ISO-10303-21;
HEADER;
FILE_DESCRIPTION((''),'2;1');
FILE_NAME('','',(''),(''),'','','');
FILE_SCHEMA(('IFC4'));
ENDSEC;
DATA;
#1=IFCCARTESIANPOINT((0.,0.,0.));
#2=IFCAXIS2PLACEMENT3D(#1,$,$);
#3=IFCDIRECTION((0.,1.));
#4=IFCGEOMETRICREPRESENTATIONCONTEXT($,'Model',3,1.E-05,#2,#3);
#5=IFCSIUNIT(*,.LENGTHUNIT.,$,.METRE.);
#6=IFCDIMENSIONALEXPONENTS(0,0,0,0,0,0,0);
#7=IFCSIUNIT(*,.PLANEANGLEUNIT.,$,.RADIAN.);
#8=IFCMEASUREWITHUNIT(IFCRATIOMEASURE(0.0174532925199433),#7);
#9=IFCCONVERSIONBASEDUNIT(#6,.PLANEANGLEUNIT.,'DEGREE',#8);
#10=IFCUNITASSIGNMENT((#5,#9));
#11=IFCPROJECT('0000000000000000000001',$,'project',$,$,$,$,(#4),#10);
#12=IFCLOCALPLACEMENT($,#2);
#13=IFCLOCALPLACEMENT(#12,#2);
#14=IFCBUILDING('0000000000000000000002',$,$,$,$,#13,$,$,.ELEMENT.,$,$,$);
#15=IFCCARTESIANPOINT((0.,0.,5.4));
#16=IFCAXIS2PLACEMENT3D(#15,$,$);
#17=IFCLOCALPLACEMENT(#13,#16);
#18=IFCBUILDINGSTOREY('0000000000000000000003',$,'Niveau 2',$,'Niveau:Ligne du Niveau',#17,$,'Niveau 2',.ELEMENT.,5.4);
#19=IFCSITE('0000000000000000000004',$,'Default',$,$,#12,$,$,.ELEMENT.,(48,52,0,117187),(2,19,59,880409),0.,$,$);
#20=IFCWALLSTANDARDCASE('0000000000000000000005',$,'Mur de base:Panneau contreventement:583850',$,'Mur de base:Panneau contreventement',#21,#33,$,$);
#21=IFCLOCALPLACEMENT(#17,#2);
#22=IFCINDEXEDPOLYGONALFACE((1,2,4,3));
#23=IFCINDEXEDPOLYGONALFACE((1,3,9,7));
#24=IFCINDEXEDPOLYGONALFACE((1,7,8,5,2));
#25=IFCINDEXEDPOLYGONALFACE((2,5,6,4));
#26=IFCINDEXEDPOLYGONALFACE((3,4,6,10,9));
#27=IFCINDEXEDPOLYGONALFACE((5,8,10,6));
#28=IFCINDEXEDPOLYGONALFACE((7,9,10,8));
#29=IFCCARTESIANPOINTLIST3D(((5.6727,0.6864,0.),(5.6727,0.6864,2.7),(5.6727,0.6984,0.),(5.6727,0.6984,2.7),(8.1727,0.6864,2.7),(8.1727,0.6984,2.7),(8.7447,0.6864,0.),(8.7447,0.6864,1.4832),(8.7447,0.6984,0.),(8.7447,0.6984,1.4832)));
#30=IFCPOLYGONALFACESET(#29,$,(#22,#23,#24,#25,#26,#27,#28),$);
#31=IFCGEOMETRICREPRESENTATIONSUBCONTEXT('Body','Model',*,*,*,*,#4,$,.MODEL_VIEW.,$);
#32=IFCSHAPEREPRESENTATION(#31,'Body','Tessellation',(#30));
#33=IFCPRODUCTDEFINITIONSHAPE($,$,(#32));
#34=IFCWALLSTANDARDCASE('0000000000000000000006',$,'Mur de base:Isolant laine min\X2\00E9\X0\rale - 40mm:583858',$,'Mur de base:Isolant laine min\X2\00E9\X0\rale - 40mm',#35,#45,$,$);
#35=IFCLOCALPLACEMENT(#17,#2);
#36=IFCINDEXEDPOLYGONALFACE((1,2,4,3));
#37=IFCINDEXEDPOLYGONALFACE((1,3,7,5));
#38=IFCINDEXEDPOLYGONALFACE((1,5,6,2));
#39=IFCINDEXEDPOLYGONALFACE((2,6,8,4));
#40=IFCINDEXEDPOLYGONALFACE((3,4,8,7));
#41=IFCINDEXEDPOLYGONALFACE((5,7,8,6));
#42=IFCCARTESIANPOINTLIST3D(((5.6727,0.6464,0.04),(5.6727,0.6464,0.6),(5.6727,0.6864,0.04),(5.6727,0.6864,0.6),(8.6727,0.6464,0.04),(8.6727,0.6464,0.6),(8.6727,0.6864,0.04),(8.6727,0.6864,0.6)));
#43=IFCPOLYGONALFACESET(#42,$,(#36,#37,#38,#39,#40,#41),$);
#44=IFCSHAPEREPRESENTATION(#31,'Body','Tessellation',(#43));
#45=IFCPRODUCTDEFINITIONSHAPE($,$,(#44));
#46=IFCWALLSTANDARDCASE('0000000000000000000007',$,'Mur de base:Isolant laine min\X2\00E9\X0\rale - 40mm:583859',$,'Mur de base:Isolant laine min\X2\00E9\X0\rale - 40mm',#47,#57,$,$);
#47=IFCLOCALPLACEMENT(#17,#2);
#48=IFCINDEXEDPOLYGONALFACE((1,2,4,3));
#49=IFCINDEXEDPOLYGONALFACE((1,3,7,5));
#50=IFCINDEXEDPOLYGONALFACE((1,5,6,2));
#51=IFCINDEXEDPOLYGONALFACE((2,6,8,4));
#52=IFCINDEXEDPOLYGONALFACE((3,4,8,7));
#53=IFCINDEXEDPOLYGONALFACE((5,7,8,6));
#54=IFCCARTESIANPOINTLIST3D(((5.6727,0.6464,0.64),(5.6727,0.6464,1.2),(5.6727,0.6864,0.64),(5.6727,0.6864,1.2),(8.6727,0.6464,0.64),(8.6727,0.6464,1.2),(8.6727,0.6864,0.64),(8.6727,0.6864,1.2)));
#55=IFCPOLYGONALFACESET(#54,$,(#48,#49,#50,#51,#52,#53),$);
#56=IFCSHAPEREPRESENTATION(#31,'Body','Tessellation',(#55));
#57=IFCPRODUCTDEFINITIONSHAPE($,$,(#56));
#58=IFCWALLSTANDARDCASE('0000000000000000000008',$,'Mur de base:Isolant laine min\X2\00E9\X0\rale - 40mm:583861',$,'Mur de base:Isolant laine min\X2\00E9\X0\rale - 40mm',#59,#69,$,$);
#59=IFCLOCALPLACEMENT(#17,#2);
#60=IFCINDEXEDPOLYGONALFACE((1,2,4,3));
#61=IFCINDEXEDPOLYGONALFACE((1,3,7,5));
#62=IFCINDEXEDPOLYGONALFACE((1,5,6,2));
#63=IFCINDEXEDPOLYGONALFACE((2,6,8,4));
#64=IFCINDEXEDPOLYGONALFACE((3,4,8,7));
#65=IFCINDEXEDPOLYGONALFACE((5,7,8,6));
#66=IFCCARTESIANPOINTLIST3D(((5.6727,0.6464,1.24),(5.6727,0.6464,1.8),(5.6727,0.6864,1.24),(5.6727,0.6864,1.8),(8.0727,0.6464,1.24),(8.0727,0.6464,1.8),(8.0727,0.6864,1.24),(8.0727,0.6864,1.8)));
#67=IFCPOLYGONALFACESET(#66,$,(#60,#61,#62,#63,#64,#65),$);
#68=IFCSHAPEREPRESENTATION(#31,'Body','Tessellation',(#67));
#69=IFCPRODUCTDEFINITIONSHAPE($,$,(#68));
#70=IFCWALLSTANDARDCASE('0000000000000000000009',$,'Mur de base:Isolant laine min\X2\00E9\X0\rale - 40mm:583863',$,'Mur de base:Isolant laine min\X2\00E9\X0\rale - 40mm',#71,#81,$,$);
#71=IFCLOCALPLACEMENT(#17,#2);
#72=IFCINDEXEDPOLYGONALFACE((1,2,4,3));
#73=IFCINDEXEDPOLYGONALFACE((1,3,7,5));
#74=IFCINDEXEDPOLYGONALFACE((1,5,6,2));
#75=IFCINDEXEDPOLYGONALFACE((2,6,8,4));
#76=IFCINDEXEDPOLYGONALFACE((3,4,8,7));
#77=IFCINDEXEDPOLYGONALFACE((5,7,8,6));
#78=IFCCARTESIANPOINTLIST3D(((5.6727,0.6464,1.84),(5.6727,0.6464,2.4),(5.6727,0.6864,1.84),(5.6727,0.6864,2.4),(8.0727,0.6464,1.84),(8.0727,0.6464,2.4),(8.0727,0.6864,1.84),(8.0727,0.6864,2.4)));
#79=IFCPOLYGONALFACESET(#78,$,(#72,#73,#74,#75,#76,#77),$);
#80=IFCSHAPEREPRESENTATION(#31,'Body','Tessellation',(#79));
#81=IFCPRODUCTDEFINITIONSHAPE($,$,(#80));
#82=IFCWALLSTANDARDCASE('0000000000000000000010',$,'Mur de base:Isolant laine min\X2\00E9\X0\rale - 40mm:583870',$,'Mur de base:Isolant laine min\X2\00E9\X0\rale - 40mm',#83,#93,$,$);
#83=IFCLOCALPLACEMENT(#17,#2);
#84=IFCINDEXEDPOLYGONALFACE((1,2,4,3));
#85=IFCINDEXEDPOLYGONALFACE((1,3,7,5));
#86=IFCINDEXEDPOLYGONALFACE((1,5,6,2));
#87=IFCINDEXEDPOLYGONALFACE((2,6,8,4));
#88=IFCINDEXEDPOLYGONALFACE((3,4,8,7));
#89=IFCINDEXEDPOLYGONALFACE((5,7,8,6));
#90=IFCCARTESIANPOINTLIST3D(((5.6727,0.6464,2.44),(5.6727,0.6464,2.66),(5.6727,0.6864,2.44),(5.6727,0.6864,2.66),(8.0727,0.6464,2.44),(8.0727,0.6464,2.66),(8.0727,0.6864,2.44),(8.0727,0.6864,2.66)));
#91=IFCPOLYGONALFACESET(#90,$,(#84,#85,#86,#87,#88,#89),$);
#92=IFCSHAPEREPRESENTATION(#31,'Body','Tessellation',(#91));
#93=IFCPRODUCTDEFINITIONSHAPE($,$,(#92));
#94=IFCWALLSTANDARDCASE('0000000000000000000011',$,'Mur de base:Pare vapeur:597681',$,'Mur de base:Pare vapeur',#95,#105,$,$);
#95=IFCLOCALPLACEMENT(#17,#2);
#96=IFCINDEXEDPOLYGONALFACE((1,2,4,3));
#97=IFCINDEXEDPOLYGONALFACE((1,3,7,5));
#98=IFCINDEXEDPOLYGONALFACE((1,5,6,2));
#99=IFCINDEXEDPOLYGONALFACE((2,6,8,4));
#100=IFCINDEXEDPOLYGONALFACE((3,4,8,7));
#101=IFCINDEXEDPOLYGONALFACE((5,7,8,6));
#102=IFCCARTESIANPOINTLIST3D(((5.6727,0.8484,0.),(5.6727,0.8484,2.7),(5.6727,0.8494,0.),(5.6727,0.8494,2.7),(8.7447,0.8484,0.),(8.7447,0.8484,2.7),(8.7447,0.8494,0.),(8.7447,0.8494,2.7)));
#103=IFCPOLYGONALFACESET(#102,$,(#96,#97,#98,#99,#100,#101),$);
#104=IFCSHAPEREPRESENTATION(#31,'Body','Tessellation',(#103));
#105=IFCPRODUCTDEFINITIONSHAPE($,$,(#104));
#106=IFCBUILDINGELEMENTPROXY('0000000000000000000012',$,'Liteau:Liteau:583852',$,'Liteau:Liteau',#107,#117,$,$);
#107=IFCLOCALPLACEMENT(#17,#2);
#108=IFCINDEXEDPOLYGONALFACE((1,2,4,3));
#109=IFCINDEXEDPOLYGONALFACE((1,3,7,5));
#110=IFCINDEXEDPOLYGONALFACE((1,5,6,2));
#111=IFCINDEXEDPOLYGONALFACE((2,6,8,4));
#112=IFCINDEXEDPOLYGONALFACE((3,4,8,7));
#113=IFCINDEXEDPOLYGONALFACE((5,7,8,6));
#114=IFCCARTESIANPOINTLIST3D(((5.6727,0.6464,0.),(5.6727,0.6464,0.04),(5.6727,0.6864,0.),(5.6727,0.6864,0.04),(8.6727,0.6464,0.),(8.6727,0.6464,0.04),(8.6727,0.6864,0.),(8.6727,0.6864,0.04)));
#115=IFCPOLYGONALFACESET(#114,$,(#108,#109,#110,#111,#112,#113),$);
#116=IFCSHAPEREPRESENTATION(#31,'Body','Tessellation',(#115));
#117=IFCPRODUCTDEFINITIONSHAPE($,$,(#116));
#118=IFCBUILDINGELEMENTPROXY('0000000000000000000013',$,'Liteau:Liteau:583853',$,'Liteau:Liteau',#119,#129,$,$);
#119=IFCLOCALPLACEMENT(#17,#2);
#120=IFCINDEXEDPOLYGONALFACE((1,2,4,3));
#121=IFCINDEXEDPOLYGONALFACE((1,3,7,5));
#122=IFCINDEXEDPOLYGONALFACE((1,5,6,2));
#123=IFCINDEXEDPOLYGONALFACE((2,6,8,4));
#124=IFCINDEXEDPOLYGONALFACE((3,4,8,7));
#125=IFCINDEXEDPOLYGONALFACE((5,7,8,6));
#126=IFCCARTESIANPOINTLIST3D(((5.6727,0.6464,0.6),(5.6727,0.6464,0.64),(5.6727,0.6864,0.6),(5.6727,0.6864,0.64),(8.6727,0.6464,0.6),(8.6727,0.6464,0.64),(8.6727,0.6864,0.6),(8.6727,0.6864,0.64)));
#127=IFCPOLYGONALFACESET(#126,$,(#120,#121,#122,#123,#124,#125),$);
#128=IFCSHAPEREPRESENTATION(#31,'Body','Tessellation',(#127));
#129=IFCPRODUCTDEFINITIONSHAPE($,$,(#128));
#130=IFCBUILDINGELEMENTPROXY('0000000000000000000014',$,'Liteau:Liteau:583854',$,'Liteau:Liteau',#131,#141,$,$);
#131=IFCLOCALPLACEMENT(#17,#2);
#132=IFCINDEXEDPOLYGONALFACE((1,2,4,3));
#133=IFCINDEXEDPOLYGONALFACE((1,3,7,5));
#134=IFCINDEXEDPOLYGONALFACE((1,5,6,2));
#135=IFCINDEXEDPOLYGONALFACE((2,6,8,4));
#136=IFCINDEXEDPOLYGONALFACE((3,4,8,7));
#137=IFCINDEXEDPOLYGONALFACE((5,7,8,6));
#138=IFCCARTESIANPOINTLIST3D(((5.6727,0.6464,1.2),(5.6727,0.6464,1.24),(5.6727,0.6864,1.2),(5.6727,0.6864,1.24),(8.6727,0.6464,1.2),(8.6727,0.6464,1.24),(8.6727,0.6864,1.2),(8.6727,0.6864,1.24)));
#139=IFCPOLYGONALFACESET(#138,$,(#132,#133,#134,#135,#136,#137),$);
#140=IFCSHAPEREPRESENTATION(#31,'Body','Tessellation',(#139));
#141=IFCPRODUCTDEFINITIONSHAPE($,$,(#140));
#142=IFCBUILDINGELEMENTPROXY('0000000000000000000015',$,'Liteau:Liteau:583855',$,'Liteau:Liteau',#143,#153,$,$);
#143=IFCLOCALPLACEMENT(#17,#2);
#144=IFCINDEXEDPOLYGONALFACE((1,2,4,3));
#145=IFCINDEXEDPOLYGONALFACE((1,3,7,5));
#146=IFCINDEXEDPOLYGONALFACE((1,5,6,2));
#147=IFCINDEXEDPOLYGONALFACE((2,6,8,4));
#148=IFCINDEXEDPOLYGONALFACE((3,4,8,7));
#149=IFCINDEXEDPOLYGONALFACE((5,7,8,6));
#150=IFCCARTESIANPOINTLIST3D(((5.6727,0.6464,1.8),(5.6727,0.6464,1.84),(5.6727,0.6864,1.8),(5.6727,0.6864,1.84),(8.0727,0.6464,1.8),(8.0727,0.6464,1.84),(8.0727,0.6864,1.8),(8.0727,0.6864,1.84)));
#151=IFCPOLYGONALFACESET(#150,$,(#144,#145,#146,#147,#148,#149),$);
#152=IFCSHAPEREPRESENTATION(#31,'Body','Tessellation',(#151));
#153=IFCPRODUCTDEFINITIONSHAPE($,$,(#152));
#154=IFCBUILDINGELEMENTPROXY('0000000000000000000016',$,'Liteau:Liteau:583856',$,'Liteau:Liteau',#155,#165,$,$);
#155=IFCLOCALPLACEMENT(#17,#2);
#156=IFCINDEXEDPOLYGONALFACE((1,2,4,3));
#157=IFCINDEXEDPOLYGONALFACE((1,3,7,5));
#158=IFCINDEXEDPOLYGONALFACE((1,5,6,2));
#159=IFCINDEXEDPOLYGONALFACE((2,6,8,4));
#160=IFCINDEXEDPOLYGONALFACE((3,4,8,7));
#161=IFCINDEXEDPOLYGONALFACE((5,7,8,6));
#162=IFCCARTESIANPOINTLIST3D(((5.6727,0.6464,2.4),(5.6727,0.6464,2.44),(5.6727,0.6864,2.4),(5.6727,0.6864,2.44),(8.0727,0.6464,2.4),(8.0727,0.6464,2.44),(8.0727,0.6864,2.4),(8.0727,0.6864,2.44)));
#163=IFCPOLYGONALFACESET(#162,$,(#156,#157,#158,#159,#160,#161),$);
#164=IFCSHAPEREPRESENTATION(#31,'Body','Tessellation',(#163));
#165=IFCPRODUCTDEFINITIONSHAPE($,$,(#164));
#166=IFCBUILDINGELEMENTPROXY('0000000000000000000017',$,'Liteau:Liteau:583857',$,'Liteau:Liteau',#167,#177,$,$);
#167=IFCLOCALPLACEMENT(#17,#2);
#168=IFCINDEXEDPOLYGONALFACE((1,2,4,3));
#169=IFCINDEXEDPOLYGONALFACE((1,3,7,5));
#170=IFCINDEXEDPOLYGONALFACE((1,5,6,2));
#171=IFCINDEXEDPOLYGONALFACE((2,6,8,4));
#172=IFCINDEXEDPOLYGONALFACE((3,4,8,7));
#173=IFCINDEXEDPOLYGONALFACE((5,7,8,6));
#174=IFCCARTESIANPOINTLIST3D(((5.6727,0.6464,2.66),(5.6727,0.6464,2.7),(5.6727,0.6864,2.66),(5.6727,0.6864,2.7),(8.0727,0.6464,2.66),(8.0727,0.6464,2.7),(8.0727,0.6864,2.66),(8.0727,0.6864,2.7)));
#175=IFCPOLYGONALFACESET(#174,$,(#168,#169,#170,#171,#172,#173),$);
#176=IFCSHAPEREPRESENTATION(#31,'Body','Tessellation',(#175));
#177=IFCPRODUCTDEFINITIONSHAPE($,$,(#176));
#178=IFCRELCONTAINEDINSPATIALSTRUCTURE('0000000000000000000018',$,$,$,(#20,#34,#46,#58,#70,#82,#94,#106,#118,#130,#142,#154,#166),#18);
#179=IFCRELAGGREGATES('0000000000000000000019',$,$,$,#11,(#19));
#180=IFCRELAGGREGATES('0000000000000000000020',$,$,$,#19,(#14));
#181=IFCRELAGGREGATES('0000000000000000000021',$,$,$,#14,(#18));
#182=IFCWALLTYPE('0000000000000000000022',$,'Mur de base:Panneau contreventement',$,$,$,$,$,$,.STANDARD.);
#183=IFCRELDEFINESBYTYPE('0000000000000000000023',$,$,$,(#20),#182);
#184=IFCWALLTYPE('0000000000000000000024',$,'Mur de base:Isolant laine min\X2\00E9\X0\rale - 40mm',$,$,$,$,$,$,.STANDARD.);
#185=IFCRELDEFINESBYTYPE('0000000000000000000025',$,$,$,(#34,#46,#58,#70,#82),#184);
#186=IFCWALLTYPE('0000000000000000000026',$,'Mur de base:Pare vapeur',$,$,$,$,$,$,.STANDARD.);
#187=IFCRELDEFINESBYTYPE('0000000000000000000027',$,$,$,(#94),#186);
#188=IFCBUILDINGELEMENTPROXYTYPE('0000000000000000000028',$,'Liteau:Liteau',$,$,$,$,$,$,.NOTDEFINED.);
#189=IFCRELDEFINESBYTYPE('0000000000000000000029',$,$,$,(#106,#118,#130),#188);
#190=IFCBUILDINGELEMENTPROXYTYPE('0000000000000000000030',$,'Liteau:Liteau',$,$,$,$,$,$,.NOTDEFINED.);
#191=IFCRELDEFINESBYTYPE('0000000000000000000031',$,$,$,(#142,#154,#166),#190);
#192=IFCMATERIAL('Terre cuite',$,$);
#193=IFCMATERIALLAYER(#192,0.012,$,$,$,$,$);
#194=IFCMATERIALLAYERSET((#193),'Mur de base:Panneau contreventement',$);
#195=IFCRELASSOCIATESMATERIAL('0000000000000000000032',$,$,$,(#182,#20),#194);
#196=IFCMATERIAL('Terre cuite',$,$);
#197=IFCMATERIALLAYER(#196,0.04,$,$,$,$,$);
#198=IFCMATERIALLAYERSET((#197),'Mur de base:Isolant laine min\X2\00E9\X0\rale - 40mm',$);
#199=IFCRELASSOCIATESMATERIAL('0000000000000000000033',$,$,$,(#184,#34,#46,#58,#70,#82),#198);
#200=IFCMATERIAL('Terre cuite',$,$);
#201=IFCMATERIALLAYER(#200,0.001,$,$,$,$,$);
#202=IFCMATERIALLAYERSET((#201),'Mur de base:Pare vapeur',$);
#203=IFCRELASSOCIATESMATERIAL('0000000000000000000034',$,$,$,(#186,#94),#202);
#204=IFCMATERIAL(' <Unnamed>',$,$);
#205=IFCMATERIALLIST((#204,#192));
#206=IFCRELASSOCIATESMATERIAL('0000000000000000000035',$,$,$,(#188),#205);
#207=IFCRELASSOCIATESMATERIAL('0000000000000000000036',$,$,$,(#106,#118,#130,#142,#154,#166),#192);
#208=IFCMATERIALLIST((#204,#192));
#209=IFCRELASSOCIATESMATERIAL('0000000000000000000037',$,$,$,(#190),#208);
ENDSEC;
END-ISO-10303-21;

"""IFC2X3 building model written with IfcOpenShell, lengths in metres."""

from ifc_helpers import new_model, entity, si_unit, converted_unit, direction, frame, frame_2d, origin, origin_2d_with_axis, place, context, subcontext, project, spatial, rectangle, extrude, clip, halfspace, source, transform, mapped, material, material_list, layer, layer_set, layer_usage, type_object, type_shapes, element, save


model = new_model("IFC2X3")

# Units and contexts
model_context = context("Model", 3, precision=1e-05, world=origin(), true_north=direction((0.0, 1.0)))
body_context = subcontext(model_context, "Body", "Model", "MODEL_VIEW")
ifc_project = project(units=[si_unit("LENGTHUNIT", "METRE"), converted_unit("PLANEANGLEUNIT", "DEGREE", entity("IfcRatioMeasure", 0.0174532925199433), si_unit("PLANEANGLEUNIT", "RADIAN"), dimensions=[0, 0, 0, 0, 0, 0, 0])], contexts=[model_context])

# Site, building, storey
site_placement = place(None, origin())
site = spatial("IfcSite", under=ifc_project, at=site_placement, Name="Default", CompositionType="ELEMENT", RefLatitude=(48, 52, 0, 117187), RefLongitude=(2, 19, 59, 880409), RefElevation=0.0)
building_placement = place(site_placement, origin())
building = spatial("IfcBuilding", under=site, at=building_placement, CompositionType="ELEMENT")
storey_placement = place(building_placement, frame((0.0, 0.0, 5.4)))
storey = spatial("IfcBuildingStorey", under=building, at=storey_placement, Name="Niveau 2", ObjectType="Niveau:Ligne du Niveau", LongName="Niveau 2", CompositionType="ELEMENT", Elevation=5.4)

# Shared definitions
ifc_material_1 = material(Name="Terre cuite")

# Walls
ifc_layer_1 = layer(ifc_material_1, 0.012)
ifc_layer_set_1 = layer_set([ifc_layer_1], Name="Mur de base:Panneau contreventement")
ifc_layer_usage_1 = layer_usage(ifc_layer_set_1, "AXIS2", "NEGATIVE", 0.006)
wall_type_1 = type_object("IfcWallType", Name="Mur de base:Panneau contreventement", PredefinedType="STANDARD", material=ifc_layer_set_1)
wall_1_placement = place(storey_placement, frame((5.6727, 0.6924, 0.0)))
element("IfcWallStandardCase", 1, at=wall_1_placement, inside=storey, type_object=wall_type_1, material=ifc_layer_usage_1, Name="Mur de base:Panneau contreventement:583850", ObjectType="Mur de base:Panneau contreventement", context=body_context, shape_type="Clipping", body=[
    clip(extrude(rectangle(XDim=3.072, YDim=0.012, at=frame_2d((1.536, 0.0), x_axis=(-1.0, 0.0))), origin(), (0.0, 0.0, 1.0), 2.7), halfspace(frame((2.5, -0.006, 2.7), z_axis=(0.904996, 0.0, 0.425419), x_axis=(0.0, 1.0, 0.0)), False)),
])
ifc_material_2 = material(Name="Terre cuite")
ifc_layer_2 = layer(ifc_material_2, 0.04)
ifc_layer_set_2 = layer_set([ifc_layer_2], Name="Mur de base:Isolant laine minérale - 40mm")
ifc_layer_usage_2 = layer_usage(ifc_layer_set_2, "AXIS2", "NEGATIVE", 0.02)
wall_type_2 = type_object("IfcWallType", Name="Mur de base:Isolant laine minérale - 40mm", PredefinedType="STANDARD", material=ifc_layer_set_2)
wall_2_placement = place(storey_placement, frame((5.6727, 0.6664, 0.04)))
element("IfcWallStandardCase", 2, at=wall_2_placement, inside=storey, type_object=wall_type_2, material=ifc_layer_usage_2, Name="Mur de base:Isolant laine minérale - 40mm:583858", ObjectType="Mur de base:Isolant laine minérale - 40mm", context=body_context, shape_type="SweptSolid", body=[
    extrude(rectangle(XDim=3.0, YDim=0.04, at=frame_2d((1.5, 0.0), x_axis=(-1.0, 0.0))), origin(), (0.0, 0.0, 1.0), 0.56),
])
ifc_layer_usage_3 = layer_usage(ifc_layer_set_2, "AXIS2", "NEGATIVE", 0.02)
wall_3_placement = place(storey_placement, frame((5.6727, 0.6664, 0.64)))
element("IfcWallStandardCase", 3, at=wall_3_placement, inside=storey, type_object=wall_type_2, material=ifc_layer_usage_3, Name="Mur de base:Isolant laine minérale - 40mm:583859", ObjectType="Mur de base:Isolant laine minérale - 40mm", context=body_context, shape_type="SweptSolid", body=[
    extrude(rectangle(XDim=3.0, YDim=0.04, at=frame_2d((1.5, 0.0), x_axis=(-1.0, 0.0))), origin(), (0.0, 0.0, 1.0), 0.56),
])
ifc_layer_usage_4 = layer_usage(ifc_layer_set_2, "AXIS2", "NEGATIVE", 0.02)
wall_4_placement = place(storey_placement, frame((5.6727, 0.6664, 1.24)))
element("IfcWallStandardCase", 4, at=wall_4_placement, inside=storey, type_object=wall_type_2, material=ifc_layer_usage_4, Name="Mur de base:Isolant laine minérale - 40mm:583861", ObjectType="Mur de base:Isolant laine minérale - 40mm", context=body_context, shape_type="SweptSolid", body=[
    extrude(rectangle(XDim=2.4, YDim=0.04, at=frame_2d((1.2, 0.0), x_axis=(-1.0, 0.0))), origin(), (0.0, 0.0, 1.0), 0.56),
])
ifc_layer_usage_5 = layer_usage(ifc_layer_set_2, "AXIS2", "NEGATIVE", 0.02)
wall_5_placement = place(storey_placement, frame((5.6727, 0.6664, 1.84)))
element("IfcWallStandardCase", 5, at=wall_5_placement, inside=storey, type_object=wall_type_2, material=ifc_layer_usage_5, Name="Mur de base:Isolant laine minérale - 40mm:583863", ObjectType="Mur de base:Isolant laine minérale - 40mm", context=body_context, shape_type="SweptSolid", body=[
    extrude(rectangle(XDim=2.4, YDim=0.04, at=frame_2d((1.2, 0.0), x_axis=(-1.0, 0.0))), origin(), (0.0, 0.0, 1.0), 0.56),
])
ifc_layer_usage_6 = layer_usage(ifc_layer_set_2, "AXIS2", "NEGATIVE", 0.02)
wall_6_placement = place(storey_placement, frame((5.6727, 0.6664, 2.44)))
element("IfcWallStandardCase", 6, at=wall_6_placement, inside=storey, type_object=wall_type_2, material=ifc_layer_usage_6, Name="Mur de base:Isolant laine minérale - 40mm:583870", ObjectType="Mur de base:Isolant laine minérale - 40mm", context=body_context, shape_type="SweptSolid", body=[
    extrude(rectangle(XDim=2.4, YDim=0.04, at=frame_2d((1.2, 0.0), x_axis=(-1.0, 0.0))), origin(), (0.0, 0.0, 1.0), 0.22),
])
ifc_material_3 = material(Name="Terre cuite")
ifc_layer_3 = layer(ifc_material_3, 0.001)
ifc_layer_set_3 = layer_set([ifc_layer_3], Name="Mur de base:Pare vapeur")
ifc_layer_usage_7 = layer_usage(ifc_layer_set_3, "AXIS2", "NEGATIVE", 0.0005)
wall_type_3 = type_object("IfcWallType", Name="Mur de base:Pare vapeur", PredefinedType="STANDARD", material=ifc_layer_set_3)
wall_7_placement = place(storey_placement, frame((5.6727, 0.8489, 0.0)))
element("IfcWallStandardCase", 7, at=wall_7_placement, inside=storey, type_object=wall_type_3, material=ifc_layer_usage_7, Name="Mur de base:Pare vapeur:597681", ObjectType="Mur de base:Pare vapeur", context=body_context, shape_type="SweptSolid", body=[
    extrude(rectangle(XDim=3.072, YDim=0.001, at=frame_2d((1.536, 0.0), x_axis=(-1.0, 0.0))), origin(), (0.0, 0.0, 1.0), 2.7),
])

# Building element proxies
ifc_material_4 = material(Name=" <Unnamed>")
ifc_material_list_1 = material_list([ifc_material_4, ifc_material_1])
building_element_proxy_type_1 = type_object("IfcBuildingElementProxyType", Name="Liteau:Liteau", PredefinedType="NOTDEFINED", material=ifc_material_list_1)
shared_shape_1 = source(origin(), body_context, "Body", "SweptSolid", [
    extrude(rectangle(XDim=3.0, YDim=0.04, at=origin_2d_with_axis()), frame((1.5, -0.02, 0.0), z_axis=(0.0, 0.0, 1.0), x_axis=(-1.0, 0.0, 0.0)), (0.0, 0.0, 1.0), 0.04),
])
type_shapes(building_element_proxy_type_1, [shared_shape_1])
for number, where, name in (
    (8, (5.6727, 0.6864, 0.0), "Liteau:Liteau:583852"),
    (9, (5.6727, 0.6864, 0.6), "Liteau:Liteau:583853"),
    (10, (5.6727, 0.6864, 1.2), "Liteau:Liteau:583854"),
):
    element("IfcBuildingElementProxy", number, at=place(storey_placement, frame(where)), inside=storey, type_object=building_element_proxy_type_1, material=ifc_material_1, Name=name, ObjectType="Liteau:Liteau", context=body_context, shape_type="MappedRepresentation", body=[
        mapped(shared_shape_1, transform((0.0, 0.0, 0.0), scale=1.0)),
    ])
ifc_material_list_2 = material_list([ifc_material_4, ifc_material_1])
building_element_proxy_type_2 = type_object("IfcBuildingElementProxyType", Name="Liteau:Liteau", PredefinedType="NOTDEFINED", material=ifc_material_list_2)
shared_shape_2 = source(origin(), body_context, "Body", "SweptSolid", [
    extrude(rectangle(XDim=2.4, YDim=0.04, at=origin_2d_with_axis()), frame((1.2, -0.02, 0.0), z_axis=(0.0, 0.0, 1.0), x_axis=(-1.0, 0.0, 0.0)), (0.0, 0.0, 1.0), 0.04),
])
type_shapes(building_element_proxy_type_2, [shared_shape_2])
for number, where, name in (
    (11, (5.6727, 0.6864, 1.8), "Liteau:Liteau:583855"),
    (12, (5.6727, 0.6864, 2.4), "Liteau:Liteau:583856"),
    (13, (5.6727, 0.6864, 2.66), "Liteau:Liteau:583857"),
):
    element("IfcBuildingElementProxy", number, at=place(storey_placement, frame(where)), inside=storey, type_object=building_element_proxy_type_2, material=ifc_material_1, Name=name, ObjectType="Liteau:Liteau", context=body_context, shape_type="MappedRepresentation", body=[
        mapped(shared_shape_2, transform((0.0, 0.0, 0.0), scale=1.0)),
    ])

save(model, "model.ifc")
